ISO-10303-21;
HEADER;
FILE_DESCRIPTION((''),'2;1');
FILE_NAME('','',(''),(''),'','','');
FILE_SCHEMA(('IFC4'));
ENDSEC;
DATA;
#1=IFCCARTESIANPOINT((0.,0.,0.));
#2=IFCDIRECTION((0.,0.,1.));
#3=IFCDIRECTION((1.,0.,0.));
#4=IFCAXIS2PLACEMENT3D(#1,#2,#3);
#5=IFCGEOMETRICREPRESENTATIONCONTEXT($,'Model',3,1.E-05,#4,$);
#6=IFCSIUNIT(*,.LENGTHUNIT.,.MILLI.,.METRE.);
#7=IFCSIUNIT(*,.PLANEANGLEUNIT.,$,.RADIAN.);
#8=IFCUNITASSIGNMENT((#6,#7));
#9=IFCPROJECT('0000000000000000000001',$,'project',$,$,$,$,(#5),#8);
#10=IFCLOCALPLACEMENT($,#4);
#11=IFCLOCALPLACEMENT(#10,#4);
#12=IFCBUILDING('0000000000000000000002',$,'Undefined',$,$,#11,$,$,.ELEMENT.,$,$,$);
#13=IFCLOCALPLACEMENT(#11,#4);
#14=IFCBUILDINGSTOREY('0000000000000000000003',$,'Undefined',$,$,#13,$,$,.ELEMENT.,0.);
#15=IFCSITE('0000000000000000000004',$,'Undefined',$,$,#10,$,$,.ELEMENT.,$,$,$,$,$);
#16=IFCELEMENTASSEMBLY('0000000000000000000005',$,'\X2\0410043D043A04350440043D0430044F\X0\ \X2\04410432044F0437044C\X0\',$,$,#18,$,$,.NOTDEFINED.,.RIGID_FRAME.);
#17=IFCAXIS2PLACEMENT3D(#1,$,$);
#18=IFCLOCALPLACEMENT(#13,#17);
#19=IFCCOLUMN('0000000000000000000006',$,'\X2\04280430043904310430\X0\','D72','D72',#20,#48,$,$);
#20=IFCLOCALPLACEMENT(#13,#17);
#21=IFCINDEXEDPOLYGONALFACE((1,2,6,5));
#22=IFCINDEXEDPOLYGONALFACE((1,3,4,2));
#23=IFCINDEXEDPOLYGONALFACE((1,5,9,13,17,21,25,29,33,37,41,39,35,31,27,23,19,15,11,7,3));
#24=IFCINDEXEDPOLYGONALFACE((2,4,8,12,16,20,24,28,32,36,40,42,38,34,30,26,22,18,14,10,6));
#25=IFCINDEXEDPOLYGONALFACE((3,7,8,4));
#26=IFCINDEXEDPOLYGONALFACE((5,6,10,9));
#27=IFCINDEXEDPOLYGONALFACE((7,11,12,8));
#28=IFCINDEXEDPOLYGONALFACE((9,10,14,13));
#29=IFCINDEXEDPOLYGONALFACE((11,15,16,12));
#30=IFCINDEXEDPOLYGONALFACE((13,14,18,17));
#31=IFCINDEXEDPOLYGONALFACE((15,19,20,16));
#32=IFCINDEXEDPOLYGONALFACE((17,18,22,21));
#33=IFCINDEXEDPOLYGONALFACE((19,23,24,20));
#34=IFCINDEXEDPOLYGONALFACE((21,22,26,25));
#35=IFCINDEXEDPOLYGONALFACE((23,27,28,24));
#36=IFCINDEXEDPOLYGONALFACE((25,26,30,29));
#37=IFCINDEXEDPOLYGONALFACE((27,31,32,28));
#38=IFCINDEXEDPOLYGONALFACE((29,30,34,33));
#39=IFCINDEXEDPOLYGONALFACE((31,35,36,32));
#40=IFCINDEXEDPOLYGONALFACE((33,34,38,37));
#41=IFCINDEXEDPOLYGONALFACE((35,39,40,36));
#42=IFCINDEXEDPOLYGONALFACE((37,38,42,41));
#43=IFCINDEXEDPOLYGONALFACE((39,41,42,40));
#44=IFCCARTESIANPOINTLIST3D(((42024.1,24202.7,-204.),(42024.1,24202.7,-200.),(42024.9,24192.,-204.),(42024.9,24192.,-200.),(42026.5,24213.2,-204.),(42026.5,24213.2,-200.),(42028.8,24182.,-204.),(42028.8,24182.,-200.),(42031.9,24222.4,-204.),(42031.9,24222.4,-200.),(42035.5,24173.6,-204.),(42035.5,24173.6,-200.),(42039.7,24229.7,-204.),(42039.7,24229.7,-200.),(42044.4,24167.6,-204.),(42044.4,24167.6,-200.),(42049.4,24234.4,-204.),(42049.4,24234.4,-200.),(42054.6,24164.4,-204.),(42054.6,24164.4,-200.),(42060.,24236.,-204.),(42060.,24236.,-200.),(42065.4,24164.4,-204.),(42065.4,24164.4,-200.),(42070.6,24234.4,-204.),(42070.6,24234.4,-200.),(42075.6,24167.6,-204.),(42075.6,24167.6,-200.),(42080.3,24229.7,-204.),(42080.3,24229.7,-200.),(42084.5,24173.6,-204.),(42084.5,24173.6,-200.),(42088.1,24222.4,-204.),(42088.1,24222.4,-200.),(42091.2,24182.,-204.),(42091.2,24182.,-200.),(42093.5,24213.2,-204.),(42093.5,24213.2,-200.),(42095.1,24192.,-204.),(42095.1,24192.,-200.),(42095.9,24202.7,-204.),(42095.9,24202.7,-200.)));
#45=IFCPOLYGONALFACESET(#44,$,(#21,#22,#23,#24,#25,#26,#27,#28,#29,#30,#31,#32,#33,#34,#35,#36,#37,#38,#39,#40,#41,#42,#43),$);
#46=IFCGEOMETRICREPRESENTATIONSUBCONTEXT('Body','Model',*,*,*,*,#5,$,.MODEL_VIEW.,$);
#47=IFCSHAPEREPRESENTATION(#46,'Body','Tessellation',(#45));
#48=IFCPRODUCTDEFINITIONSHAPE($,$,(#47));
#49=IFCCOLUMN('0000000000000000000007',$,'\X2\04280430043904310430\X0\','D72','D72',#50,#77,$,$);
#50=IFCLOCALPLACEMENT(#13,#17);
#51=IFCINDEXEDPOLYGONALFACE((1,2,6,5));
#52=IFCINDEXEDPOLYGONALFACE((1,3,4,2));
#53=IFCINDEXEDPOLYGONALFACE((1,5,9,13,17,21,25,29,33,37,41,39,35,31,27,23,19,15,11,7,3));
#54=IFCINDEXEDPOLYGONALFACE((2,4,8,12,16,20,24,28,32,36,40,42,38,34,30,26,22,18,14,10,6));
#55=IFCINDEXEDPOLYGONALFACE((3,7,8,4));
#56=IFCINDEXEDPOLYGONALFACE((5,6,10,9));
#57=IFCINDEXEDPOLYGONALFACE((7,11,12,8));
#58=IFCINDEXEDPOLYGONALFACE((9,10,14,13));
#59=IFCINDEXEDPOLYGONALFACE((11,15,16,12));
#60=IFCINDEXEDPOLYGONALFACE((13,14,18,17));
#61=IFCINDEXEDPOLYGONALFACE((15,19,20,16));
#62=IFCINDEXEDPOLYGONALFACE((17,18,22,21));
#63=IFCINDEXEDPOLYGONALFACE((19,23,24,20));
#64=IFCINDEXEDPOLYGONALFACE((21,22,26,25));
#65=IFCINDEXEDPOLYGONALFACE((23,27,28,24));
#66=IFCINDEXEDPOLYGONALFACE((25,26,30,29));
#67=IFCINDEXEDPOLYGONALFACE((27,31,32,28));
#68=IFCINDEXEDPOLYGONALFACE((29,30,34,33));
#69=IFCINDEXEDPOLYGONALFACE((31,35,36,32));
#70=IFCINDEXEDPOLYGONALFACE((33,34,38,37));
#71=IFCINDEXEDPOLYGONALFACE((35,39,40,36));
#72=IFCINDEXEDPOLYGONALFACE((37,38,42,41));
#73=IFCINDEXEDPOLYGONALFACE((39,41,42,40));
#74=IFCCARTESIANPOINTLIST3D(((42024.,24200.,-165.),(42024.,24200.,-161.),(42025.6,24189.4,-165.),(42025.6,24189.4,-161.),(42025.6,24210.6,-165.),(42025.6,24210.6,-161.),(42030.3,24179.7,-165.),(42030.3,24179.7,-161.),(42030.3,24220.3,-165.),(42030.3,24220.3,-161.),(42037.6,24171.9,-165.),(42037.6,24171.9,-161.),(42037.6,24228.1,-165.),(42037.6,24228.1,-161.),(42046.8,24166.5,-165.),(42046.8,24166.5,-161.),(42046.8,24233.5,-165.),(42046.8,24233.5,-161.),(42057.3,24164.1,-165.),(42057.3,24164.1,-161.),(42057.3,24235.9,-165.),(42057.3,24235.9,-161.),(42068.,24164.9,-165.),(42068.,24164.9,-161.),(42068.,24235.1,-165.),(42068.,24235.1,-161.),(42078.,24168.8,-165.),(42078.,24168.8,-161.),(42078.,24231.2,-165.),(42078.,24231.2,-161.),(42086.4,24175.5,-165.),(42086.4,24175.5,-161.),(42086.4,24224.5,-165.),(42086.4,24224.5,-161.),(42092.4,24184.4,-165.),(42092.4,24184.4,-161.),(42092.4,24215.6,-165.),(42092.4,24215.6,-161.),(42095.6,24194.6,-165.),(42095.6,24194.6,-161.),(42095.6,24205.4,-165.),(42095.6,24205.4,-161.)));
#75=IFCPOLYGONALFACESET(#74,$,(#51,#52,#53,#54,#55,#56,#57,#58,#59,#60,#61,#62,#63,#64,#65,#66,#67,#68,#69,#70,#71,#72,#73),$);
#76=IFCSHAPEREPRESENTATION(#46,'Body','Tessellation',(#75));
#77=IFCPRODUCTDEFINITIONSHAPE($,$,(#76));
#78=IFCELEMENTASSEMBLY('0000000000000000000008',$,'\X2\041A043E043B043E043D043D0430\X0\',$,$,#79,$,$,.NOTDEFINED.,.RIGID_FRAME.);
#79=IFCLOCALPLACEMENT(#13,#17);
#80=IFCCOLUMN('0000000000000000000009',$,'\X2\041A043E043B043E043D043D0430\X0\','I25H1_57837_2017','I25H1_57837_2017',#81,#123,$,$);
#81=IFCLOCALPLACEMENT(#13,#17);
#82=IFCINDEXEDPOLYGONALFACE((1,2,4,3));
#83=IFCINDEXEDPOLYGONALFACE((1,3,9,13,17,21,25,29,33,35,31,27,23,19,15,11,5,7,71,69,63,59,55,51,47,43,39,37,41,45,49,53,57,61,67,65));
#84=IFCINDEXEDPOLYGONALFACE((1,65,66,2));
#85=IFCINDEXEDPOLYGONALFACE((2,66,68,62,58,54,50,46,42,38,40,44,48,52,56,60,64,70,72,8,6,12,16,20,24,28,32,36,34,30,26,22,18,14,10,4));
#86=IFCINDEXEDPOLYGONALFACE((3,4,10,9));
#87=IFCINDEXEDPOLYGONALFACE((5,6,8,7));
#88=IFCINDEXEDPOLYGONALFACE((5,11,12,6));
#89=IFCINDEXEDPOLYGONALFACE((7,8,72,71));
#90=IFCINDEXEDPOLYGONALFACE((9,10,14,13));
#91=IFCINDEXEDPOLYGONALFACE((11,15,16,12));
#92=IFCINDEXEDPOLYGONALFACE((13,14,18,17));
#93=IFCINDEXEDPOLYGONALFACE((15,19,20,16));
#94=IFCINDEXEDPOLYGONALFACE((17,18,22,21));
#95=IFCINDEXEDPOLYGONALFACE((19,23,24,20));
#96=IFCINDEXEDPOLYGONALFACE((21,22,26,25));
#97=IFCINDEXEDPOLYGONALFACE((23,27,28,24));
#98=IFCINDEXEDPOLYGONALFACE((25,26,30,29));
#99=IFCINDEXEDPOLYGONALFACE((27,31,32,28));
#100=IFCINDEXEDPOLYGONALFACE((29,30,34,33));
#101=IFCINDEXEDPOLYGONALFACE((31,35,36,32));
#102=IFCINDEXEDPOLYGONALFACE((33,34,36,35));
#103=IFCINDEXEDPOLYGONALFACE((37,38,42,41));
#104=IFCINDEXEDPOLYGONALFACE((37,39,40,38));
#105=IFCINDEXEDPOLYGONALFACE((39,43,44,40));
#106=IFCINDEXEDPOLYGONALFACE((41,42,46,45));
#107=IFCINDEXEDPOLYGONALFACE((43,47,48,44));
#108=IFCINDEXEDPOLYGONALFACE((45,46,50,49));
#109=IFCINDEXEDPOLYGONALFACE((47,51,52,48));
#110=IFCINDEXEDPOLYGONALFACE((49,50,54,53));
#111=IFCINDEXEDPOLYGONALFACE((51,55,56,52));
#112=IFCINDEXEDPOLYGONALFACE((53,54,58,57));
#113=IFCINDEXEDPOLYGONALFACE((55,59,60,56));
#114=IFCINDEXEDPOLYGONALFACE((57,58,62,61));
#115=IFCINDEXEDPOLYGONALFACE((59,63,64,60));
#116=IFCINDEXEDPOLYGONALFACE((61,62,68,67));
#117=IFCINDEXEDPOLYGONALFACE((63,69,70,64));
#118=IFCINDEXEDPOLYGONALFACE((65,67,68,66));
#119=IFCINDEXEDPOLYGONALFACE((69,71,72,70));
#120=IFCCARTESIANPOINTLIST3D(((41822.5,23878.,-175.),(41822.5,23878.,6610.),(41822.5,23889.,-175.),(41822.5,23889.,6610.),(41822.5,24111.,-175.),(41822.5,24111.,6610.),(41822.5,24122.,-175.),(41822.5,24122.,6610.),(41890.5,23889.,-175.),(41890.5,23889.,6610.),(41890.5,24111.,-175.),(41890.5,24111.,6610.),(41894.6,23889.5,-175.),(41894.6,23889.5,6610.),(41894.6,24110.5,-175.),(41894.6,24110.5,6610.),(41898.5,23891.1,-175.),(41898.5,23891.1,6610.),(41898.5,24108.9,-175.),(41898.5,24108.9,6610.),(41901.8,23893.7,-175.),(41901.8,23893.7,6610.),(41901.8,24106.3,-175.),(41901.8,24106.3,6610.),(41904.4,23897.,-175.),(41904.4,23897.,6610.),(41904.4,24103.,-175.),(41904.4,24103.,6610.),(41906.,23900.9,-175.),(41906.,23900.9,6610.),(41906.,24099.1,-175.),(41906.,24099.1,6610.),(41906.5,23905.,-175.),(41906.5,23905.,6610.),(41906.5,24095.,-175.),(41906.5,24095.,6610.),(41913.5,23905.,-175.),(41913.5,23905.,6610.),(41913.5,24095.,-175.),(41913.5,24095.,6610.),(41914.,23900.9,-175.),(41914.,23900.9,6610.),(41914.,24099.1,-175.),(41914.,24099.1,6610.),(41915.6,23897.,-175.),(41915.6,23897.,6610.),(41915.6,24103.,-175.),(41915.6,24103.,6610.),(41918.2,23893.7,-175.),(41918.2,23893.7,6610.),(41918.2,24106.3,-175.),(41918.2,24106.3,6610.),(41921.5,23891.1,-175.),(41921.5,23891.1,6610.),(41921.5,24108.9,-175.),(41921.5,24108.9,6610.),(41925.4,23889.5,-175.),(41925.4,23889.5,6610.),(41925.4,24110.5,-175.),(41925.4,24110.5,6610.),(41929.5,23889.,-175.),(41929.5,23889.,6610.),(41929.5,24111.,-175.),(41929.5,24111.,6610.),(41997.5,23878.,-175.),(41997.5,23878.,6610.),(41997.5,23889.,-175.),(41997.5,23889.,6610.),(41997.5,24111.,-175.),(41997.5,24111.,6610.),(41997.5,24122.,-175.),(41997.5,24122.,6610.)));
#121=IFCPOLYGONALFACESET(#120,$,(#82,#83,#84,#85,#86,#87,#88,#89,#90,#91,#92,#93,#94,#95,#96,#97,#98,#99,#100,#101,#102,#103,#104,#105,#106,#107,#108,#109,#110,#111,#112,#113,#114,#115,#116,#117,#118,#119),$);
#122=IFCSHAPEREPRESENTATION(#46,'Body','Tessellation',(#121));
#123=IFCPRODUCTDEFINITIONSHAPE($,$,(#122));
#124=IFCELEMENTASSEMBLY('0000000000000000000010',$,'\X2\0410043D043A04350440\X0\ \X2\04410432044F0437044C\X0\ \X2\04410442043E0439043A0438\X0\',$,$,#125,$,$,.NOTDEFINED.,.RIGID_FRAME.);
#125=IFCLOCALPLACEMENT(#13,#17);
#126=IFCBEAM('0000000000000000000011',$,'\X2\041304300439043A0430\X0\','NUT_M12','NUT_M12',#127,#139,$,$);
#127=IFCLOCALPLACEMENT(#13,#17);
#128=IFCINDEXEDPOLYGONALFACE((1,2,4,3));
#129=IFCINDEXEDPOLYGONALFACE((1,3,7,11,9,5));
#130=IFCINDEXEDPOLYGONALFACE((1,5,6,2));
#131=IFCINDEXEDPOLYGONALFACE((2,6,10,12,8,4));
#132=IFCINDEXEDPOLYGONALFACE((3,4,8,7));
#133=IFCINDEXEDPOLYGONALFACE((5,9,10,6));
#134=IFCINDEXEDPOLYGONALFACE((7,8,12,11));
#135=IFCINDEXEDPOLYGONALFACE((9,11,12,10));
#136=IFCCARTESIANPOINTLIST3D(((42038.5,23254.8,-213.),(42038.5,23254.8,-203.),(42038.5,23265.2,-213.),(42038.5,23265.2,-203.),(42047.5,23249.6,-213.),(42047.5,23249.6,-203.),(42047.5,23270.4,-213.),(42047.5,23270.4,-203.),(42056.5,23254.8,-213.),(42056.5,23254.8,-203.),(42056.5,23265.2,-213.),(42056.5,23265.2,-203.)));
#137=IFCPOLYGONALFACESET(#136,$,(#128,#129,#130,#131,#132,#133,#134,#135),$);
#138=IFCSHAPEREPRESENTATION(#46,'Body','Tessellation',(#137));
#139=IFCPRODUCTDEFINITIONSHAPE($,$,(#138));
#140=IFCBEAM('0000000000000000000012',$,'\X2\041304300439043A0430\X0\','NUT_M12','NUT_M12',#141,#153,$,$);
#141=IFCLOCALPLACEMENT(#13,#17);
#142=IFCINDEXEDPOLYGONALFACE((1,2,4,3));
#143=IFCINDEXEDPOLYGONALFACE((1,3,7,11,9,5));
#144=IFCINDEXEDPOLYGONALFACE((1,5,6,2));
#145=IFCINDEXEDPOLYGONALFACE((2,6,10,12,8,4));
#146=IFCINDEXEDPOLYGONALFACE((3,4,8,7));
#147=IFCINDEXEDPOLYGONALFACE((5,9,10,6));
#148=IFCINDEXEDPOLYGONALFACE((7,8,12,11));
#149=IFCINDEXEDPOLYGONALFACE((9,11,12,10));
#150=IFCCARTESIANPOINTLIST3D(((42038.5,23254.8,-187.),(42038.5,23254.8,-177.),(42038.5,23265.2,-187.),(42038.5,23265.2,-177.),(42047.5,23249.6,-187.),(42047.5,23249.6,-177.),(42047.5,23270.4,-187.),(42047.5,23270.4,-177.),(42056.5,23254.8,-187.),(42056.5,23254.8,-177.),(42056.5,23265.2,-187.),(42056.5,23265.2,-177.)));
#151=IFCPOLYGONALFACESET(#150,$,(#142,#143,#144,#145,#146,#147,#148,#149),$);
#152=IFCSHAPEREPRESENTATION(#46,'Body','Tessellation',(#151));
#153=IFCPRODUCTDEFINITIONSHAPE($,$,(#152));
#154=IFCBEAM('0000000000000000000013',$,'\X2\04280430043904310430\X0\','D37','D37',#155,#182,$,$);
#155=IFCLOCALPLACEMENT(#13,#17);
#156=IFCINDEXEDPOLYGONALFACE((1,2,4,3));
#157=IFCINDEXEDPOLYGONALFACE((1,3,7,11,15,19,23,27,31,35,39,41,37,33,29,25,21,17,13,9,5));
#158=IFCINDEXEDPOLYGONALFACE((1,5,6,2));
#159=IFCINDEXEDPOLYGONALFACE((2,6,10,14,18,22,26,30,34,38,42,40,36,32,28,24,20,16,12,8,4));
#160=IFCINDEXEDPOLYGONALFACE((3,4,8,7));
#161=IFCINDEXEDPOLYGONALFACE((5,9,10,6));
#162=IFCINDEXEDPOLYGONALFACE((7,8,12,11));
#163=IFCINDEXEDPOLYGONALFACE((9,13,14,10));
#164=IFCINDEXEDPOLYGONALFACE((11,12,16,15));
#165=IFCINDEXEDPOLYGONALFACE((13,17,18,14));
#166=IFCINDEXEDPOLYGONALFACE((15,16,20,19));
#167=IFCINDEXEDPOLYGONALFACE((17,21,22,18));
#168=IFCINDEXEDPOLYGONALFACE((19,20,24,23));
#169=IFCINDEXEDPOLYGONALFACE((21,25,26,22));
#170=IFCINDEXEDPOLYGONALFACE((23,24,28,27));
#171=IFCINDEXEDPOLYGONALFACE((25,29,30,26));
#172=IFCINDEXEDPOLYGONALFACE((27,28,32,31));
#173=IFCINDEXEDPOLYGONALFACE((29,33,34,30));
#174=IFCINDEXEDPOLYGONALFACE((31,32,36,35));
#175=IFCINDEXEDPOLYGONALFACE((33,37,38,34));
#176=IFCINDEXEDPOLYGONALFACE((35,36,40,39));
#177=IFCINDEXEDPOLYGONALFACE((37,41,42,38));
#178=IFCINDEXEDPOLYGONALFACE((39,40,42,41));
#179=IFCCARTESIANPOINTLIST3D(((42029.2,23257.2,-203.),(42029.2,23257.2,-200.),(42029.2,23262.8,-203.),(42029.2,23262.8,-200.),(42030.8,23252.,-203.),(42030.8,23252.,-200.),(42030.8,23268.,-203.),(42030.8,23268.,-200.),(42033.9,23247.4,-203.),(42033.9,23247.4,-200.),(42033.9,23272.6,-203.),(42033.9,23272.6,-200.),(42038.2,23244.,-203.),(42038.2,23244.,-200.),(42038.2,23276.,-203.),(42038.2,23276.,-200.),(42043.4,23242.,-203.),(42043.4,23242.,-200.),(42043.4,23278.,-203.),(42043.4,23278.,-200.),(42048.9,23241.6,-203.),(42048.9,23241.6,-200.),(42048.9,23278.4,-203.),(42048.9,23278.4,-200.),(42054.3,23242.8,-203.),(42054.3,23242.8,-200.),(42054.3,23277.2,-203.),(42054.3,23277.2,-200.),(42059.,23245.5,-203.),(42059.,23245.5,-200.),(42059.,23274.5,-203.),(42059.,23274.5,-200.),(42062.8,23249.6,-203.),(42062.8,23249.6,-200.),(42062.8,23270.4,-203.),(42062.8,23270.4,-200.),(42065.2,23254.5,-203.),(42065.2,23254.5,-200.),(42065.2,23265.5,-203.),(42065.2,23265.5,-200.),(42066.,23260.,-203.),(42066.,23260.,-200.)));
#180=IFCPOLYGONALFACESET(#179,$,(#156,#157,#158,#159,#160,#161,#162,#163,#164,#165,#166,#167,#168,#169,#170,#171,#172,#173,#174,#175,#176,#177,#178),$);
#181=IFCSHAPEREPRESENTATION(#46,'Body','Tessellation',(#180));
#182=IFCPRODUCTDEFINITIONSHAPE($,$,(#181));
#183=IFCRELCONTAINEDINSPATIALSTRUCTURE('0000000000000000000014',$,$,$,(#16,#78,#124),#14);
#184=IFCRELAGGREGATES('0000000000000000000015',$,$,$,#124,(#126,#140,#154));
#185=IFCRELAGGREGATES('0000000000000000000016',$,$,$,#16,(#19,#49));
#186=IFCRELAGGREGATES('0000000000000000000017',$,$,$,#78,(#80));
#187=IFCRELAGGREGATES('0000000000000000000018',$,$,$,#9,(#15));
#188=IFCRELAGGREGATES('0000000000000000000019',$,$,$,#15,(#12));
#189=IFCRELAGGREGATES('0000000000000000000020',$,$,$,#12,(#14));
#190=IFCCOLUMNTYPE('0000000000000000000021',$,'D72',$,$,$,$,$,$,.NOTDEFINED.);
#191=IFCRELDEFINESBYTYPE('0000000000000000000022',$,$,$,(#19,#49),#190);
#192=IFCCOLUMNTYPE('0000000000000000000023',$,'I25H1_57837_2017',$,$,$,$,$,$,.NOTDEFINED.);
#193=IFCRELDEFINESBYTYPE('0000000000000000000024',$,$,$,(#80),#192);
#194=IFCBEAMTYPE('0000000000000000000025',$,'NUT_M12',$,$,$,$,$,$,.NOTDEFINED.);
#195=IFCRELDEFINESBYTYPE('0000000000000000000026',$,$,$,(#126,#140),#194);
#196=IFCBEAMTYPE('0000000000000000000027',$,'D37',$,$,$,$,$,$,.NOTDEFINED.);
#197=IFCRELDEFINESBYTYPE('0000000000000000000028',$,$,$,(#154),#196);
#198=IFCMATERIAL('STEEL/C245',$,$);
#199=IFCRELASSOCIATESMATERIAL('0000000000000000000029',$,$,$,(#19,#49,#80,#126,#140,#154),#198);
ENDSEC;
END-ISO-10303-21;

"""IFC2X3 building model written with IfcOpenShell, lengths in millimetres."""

from ifc_helpers import new_model, si_unit, frame, origin_with_axes, origin_2d_with_axis, place, context, subcontext, project, spatial, polyline, circle, i_section, outline, extrude, clip, halfspace, material, type_object, element, aggregate, save


model = new_model("IFC2X3")

# Units and contexts
model_context = context("Model", 3, precision=1e-05, world=origin_with_axes())
body_context = subcontext(model_context, "Body", "Model", "MODEL_VIEW")
ifc_project = project(units=[si_unit("LENGTHUNIT", "METRE", prefix="MILLI"), si_unit("PLANEANGLEUNIT", "RADIAN")], contexts=[model_context])

# Site, building, storey
site_placement = place(None, origin_with_axes())
site = spatial("IfcSite", under=ifc_project, at=site_placement, Name="Undefined", CompositionType="ELEMENT")
building_placement = place(site_placement, origin_with_axes())
building = spatial("IfcBuilding", under=site, at=building_placement, Name="Undefined", CompositionType="ELEMENT")
storey_placement = place(building_placement, origin_with_axes())
storey = spatial("IfcBuildingStorey", under=building, at=storey_placement, Name="Undefined", CompositionType="ELEMENT", Elevation=0.0)

# Shared definitions
ifc_material_1 = material(Name="STEEL/C245")

# Element assembly
assembly_1_placement = place(storey_placement, origin_with_axes())
assembly_1 = element("IfcElementAssembly", 1, at=assembly_1_placement, inside=storey, Name="Анкерная связь", AssemblyPlace="NOTDEFINED", PredefinedType="RIGID_FRAME")

# Columns
column_type_1 = type_object("IfcColumnType", Name="D72", PredefinedType="NOTDEFINED")
column_1_placement = place(assembly_1_placement, frame((42060.0, 24200.0, -200.0), z_axis=(0.0, 0.0, -1.0), x_axis=(-1.0, 0.0, 0.0)))
column_1 = element("IfcColumn", 2, at=column_1_placement, type_object=column_type_1, material=ifc_material_1, Name="Шайба", Description="D72", ObjectType="D72", context=body_context, shape_type="SweptSolid", body=[
    extrude(circle(Radius=36.0, at=origin_2d_with_axis()), frame((0.0, 0.0, 4.0), z_axis=(0.0, 0.0, -1.0), x_axis=(0.0, 1.0, 0.0)), (0.0, 0.0, 1.0), 4.0),
])
column_2_placement = place(assembly_1_placement, frame((42060.0, 24200.0, -161.0), z_axis=(0.0, 0.0, -1.0), x_axis=(0.0, -1.0, 0.0)))
column_2 = element("IfcColumn", 3, at=column_2_placement, type_object=column_type_1, material=ifc_material_1, Name="Шайба", Description="D72", ObjectType="D72", context=body_context, shape_type="SweptSolid", body=[
    extrude(circle(Radius=36.0, at=origin_2d_with_axis()), frame((0.0, 0.0, 4.0), z_axis=(0.0, 0.0, -1.0), x_axis=(0.0, 1.0, 0.0)), (0.0, 0.0, 1.0), 4.0),
])

# Element assembly, column
assembly_2_placement = place(storey_placement, origin_with_axes())
assembly_2 = element("IfcElementAssembly", 4, at=assembly_2_placement, inside=storey, Name="Колонна", AssemblyPlace="NOTDEFINED", PredefinedType="RIGID_FRAME")
column_type_2 = type_object("IfcColumnType", Name="I25H1_57837_2017", PredefinedType="NOTDEFINED")
column_3_placement = place(assembly_2_placement, frame((41910.0, 24000.0, 0.0), z_axis=(0.0, 0.0, 1.0), x_axis=(0.0, 1.0, 0.0)))
column_3 = element("IfcColumn", 5, at=column_3_placement, type_object=column_type_2, material=ifc_material_1, Name="Колонна", Description="I25H1_57837_2017", ObjectType="I25H1_57837_2017", context=body_context, shape_type="Clipping", body=[
    clip(extrude(i_section(OverallWidth=175.0, OverallDepth=244.0, WebThickness=7.0, FlangeThickness=11.0, FilletRadius=16.0, at=origin_2d_with_axis()), frame((0.0, 0.0, 6610.0), z_axis=(0.0, 0.0, -1.0), x_axis=(0.0, 1.0, 0.0)), (0.0, 0.0, 1.0), 6785.0), halfspace(frame((-122.0, 0.0, -175.0), z_axis=(0.0, 0.0, 1.0), x_axis=(0.0, 1.0, 0.0)), True)),
])

# Element assembly, beams
assembly_3_placement = place(storey_placement, origin_with_axes())
assembly_3 = element("IfcElementAssembly", 6, at=assembly_3_placement, inside=storey, Name="Анкер связь стойки", AssemblyPlace="NOTDEFINED", PredefinedType="RIGID_FRAME")
beam_type_1 = type_object("IfcBeamType", Name="NUT_M12", PredefinedType="NOTDEFINED")
beam_1_placement = place(assembly_3_placement, frame((42047.5, 23260.0, -203.0), z_axis=(-1.0, 0.0, 0.0), x_axis=(0.0, 0.0, -1.0)))
beam_1 = element("IfcBeam", 7, at=beam_1_placement, type_object=beam_type_1, material=ifc_material_1, Name="Гайка", Description="NUT_M12", ObjectType="NUT_M12", context=body_context, shape_type="SweptSolid", body=[
    extrude(outline(polyline([(5.2, -9.0), (-5.2, -9.0), (-10.4, 0.0), (-5.2, 9.0), (5.2, 9.0), (10.4, 0.0), (5.2, -9.0)])), frame((10.0, 0.0, 0.0), z_axis=(-1.0, 0.0, 0.0), x_axis=(0.0, -1.0, 0.0)), (0.0, 0.0, 1.0), 10.0),
])
beam_2_placement = place(assembly_3_placement, frame((42047.5, 23260.0, -177.0), z_axis=(-1.0, 0.0, 0.0), x_axis=(0.0, 0.0, -1.0)))
beam_2 = element("IfcBeam", 8, at=beam_2_placement, type_object=beam_type_1, material=ifc_material_1, Name="Гайка", Description="NUT_M12", ObjectType="NUT_M12", context=body_context, shape_type="SweptSolid", body=[
    extrude(outline(polyline([(5.2, -9.0), (-5.2, -9.0), (-10.4, 0.0), (-5.2, 9.0), (5.2, 9.0), (10.4, 0.0), (5.2, -9.0)])), frame((10.0, 0.0, 0.0), z_axis=(-1.0, 0.0, 0.0), x_axis=(0.0, -1.0, 0.0)), (0.0, 0.0, 1.0), 10.0),
])
beam_type_2 = type_object("IfcBeamType", Name="D37", PredefinedType="NOTDEFINED")
beam_3_placement = place(assembly_3_placement, frame((42047.5, 23260.0, -200.0), z_axis=(0.0, 1.0, 0.0), x_axis=(0.0, 0.0, -1.0)))
beam_3 = element("IfcBeam", 9, at=beam_3_placement, type_object=beam_type_2, material=ifc_material_1, Name="Шайба", Description="D37", ObjectType="D37", context=body_context, shape_type="SweptSolid", body=[
    extrude(circle(Radius=18.5, at=origin_2d_with_axis()), frame((3.0, 0.0, 0.0), z_axis=(-1.0, 0.0, 0.0), x_axis=(0.0, -1.0, 0.0)), (0.0, 0.0, 1.0), 3.0),
])

aggregate(assembly_3, [beam_1, beam_2, beam_3])

aggregate(assembly_1, [column_1, column_2])
aggregate(assembly_2, [column_3])

save(model, "model.ifc")
